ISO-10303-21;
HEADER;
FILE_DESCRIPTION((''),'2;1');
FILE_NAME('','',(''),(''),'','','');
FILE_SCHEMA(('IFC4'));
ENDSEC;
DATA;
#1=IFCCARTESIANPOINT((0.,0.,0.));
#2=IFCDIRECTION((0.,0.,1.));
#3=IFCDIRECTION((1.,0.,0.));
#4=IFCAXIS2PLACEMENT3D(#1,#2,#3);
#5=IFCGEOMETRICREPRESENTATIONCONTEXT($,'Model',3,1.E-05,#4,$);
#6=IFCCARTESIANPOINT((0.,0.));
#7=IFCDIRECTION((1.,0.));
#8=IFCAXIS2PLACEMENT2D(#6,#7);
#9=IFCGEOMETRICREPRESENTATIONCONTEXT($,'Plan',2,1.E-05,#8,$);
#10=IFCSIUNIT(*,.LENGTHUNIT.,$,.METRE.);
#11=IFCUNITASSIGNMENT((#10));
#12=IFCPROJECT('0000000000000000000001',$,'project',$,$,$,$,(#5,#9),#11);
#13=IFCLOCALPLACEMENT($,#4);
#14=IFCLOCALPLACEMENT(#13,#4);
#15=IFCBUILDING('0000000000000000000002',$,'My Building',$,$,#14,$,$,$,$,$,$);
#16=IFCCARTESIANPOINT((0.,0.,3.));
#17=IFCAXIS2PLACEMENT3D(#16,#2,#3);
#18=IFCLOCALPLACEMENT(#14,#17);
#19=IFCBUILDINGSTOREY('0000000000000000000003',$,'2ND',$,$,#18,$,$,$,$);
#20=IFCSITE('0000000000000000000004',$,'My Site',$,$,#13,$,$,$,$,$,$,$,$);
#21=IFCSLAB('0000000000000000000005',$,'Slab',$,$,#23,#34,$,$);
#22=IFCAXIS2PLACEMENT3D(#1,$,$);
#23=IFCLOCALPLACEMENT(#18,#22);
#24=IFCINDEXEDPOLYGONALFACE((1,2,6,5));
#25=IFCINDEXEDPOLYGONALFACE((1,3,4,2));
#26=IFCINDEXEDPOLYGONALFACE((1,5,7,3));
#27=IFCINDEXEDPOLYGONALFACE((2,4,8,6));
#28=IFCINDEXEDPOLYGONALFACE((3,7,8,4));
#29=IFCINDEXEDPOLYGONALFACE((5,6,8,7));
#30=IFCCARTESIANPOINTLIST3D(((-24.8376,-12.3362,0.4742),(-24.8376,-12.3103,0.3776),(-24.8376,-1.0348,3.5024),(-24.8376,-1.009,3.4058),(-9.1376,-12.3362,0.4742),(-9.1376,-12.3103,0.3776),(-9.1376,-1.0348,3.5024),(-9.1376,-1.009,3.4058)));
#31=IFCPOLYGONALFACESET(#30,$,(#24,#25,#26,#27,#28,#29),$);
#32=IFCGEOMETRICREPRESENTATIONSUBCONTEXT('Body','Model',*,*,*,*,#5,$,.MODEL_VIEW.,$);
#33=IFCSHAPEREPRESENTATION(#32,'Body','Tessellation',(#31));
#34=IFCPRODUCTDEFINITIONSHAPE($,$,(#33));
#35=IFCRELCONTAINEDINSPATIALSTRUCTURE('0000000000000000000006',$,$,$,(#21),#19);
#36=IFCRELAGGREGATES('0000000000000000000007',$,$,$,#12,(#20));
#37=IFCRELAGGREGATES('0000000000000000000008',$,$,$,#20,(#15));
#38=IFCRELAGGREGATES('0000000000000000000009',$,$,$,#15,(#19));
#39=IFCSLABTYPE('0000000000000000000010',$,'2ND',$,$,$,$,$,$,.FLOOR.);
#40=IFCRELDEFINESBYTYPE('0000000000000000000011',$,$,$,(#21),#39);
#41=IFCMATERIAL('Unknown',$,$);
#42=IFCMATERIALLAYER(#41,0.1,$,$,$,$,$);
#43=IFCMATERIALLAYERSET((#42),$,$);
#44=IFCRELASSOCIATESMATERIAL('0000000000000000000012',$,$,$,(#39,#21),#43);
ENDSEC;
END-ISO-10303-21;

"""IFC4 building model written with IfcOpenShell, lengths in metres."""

from ifc_helpers import new_model, si_unit, frame, origin_with_axes, origin_2d_with_axis, place, context, subcontext, project, spatial, indexed_curve, outline, extrude, material, layer, layer_set, layer_usage, type_object, element, save


model = new_model("IFC4")

# Units and contexts
model_context = context("Model", 3, precision=1e-05, world=origin_with_axes())
plan_context = context("Plan", 2, precision=1e-05, world=origin_2d_with_axis())
body_context = subcontext(model_context, "Body", "Model", "MODEL_VIEW")
ifc_project = project(units=[si_unit("LENGTHUNIT", "METRE")], contexts=[model_context, plan_context])

# Site, building, storey
site_placement = place(None, origin_with_axes())
site = spatial("IfcSite", under=ifc_project, at=site_placement, Name="My Site")
building_placement = place(site_placement, origin_with_axes())
building = spatial("IfcBuilding", under=site, at=building_placement, Name="My Building")
storey_placement = place(building_placement, frame((0.0, 0.0, 3.0), z_axis=(0.0, 0.0, 1.0), x_axis=(1.0, 0.0, 0.0)))
storey = spatial("IfcBuildingStorey", under=building, at=storey_placement, Name="2ND")

# Slab
ifc_material = material(Name="Unknown")
ifc_layer = layer(ifc_material, 0.1)
ifc_layer_set = layer_set([ifc_layer])
ifc_layer_usage = layer_usage(ifc_layer_set, "AXIS3", "POSITIVE", -0.1)
slab_type = type_object("IfcSlabType", Name="2ND", PredefinedType="FLOOR", material=ifc_layer_set)
slab_placement = place(storey_placement, frame((-9.1376, -1.0348, 3.5024), z_axis=(0.0, -0.258819, 0.965926), x_axis=(0.0, -0.965926, -0.258819)))
element("IfcSlab", 1, at=slab_placement, inside=storey, type_object=slab_type, material=ifc_layer_usage, Name="Slab", context=body_context, shape_type="SweptSolid", body=[
    extrude(outline(indexed_curve([(0.0, 0.0), (11.7, 0.0), (11.7, -15.7), (0.0, -15.7), (0.0, 0.0)])), frame((0.0, 0.0, -0.1), z_axis=(0.0, 0.0, 1.0), x_axis=(1.0, 0.0, 0.0)), (0.0, 0.0, 1.0), 0.1),
])

save(model, "model.ifc")
